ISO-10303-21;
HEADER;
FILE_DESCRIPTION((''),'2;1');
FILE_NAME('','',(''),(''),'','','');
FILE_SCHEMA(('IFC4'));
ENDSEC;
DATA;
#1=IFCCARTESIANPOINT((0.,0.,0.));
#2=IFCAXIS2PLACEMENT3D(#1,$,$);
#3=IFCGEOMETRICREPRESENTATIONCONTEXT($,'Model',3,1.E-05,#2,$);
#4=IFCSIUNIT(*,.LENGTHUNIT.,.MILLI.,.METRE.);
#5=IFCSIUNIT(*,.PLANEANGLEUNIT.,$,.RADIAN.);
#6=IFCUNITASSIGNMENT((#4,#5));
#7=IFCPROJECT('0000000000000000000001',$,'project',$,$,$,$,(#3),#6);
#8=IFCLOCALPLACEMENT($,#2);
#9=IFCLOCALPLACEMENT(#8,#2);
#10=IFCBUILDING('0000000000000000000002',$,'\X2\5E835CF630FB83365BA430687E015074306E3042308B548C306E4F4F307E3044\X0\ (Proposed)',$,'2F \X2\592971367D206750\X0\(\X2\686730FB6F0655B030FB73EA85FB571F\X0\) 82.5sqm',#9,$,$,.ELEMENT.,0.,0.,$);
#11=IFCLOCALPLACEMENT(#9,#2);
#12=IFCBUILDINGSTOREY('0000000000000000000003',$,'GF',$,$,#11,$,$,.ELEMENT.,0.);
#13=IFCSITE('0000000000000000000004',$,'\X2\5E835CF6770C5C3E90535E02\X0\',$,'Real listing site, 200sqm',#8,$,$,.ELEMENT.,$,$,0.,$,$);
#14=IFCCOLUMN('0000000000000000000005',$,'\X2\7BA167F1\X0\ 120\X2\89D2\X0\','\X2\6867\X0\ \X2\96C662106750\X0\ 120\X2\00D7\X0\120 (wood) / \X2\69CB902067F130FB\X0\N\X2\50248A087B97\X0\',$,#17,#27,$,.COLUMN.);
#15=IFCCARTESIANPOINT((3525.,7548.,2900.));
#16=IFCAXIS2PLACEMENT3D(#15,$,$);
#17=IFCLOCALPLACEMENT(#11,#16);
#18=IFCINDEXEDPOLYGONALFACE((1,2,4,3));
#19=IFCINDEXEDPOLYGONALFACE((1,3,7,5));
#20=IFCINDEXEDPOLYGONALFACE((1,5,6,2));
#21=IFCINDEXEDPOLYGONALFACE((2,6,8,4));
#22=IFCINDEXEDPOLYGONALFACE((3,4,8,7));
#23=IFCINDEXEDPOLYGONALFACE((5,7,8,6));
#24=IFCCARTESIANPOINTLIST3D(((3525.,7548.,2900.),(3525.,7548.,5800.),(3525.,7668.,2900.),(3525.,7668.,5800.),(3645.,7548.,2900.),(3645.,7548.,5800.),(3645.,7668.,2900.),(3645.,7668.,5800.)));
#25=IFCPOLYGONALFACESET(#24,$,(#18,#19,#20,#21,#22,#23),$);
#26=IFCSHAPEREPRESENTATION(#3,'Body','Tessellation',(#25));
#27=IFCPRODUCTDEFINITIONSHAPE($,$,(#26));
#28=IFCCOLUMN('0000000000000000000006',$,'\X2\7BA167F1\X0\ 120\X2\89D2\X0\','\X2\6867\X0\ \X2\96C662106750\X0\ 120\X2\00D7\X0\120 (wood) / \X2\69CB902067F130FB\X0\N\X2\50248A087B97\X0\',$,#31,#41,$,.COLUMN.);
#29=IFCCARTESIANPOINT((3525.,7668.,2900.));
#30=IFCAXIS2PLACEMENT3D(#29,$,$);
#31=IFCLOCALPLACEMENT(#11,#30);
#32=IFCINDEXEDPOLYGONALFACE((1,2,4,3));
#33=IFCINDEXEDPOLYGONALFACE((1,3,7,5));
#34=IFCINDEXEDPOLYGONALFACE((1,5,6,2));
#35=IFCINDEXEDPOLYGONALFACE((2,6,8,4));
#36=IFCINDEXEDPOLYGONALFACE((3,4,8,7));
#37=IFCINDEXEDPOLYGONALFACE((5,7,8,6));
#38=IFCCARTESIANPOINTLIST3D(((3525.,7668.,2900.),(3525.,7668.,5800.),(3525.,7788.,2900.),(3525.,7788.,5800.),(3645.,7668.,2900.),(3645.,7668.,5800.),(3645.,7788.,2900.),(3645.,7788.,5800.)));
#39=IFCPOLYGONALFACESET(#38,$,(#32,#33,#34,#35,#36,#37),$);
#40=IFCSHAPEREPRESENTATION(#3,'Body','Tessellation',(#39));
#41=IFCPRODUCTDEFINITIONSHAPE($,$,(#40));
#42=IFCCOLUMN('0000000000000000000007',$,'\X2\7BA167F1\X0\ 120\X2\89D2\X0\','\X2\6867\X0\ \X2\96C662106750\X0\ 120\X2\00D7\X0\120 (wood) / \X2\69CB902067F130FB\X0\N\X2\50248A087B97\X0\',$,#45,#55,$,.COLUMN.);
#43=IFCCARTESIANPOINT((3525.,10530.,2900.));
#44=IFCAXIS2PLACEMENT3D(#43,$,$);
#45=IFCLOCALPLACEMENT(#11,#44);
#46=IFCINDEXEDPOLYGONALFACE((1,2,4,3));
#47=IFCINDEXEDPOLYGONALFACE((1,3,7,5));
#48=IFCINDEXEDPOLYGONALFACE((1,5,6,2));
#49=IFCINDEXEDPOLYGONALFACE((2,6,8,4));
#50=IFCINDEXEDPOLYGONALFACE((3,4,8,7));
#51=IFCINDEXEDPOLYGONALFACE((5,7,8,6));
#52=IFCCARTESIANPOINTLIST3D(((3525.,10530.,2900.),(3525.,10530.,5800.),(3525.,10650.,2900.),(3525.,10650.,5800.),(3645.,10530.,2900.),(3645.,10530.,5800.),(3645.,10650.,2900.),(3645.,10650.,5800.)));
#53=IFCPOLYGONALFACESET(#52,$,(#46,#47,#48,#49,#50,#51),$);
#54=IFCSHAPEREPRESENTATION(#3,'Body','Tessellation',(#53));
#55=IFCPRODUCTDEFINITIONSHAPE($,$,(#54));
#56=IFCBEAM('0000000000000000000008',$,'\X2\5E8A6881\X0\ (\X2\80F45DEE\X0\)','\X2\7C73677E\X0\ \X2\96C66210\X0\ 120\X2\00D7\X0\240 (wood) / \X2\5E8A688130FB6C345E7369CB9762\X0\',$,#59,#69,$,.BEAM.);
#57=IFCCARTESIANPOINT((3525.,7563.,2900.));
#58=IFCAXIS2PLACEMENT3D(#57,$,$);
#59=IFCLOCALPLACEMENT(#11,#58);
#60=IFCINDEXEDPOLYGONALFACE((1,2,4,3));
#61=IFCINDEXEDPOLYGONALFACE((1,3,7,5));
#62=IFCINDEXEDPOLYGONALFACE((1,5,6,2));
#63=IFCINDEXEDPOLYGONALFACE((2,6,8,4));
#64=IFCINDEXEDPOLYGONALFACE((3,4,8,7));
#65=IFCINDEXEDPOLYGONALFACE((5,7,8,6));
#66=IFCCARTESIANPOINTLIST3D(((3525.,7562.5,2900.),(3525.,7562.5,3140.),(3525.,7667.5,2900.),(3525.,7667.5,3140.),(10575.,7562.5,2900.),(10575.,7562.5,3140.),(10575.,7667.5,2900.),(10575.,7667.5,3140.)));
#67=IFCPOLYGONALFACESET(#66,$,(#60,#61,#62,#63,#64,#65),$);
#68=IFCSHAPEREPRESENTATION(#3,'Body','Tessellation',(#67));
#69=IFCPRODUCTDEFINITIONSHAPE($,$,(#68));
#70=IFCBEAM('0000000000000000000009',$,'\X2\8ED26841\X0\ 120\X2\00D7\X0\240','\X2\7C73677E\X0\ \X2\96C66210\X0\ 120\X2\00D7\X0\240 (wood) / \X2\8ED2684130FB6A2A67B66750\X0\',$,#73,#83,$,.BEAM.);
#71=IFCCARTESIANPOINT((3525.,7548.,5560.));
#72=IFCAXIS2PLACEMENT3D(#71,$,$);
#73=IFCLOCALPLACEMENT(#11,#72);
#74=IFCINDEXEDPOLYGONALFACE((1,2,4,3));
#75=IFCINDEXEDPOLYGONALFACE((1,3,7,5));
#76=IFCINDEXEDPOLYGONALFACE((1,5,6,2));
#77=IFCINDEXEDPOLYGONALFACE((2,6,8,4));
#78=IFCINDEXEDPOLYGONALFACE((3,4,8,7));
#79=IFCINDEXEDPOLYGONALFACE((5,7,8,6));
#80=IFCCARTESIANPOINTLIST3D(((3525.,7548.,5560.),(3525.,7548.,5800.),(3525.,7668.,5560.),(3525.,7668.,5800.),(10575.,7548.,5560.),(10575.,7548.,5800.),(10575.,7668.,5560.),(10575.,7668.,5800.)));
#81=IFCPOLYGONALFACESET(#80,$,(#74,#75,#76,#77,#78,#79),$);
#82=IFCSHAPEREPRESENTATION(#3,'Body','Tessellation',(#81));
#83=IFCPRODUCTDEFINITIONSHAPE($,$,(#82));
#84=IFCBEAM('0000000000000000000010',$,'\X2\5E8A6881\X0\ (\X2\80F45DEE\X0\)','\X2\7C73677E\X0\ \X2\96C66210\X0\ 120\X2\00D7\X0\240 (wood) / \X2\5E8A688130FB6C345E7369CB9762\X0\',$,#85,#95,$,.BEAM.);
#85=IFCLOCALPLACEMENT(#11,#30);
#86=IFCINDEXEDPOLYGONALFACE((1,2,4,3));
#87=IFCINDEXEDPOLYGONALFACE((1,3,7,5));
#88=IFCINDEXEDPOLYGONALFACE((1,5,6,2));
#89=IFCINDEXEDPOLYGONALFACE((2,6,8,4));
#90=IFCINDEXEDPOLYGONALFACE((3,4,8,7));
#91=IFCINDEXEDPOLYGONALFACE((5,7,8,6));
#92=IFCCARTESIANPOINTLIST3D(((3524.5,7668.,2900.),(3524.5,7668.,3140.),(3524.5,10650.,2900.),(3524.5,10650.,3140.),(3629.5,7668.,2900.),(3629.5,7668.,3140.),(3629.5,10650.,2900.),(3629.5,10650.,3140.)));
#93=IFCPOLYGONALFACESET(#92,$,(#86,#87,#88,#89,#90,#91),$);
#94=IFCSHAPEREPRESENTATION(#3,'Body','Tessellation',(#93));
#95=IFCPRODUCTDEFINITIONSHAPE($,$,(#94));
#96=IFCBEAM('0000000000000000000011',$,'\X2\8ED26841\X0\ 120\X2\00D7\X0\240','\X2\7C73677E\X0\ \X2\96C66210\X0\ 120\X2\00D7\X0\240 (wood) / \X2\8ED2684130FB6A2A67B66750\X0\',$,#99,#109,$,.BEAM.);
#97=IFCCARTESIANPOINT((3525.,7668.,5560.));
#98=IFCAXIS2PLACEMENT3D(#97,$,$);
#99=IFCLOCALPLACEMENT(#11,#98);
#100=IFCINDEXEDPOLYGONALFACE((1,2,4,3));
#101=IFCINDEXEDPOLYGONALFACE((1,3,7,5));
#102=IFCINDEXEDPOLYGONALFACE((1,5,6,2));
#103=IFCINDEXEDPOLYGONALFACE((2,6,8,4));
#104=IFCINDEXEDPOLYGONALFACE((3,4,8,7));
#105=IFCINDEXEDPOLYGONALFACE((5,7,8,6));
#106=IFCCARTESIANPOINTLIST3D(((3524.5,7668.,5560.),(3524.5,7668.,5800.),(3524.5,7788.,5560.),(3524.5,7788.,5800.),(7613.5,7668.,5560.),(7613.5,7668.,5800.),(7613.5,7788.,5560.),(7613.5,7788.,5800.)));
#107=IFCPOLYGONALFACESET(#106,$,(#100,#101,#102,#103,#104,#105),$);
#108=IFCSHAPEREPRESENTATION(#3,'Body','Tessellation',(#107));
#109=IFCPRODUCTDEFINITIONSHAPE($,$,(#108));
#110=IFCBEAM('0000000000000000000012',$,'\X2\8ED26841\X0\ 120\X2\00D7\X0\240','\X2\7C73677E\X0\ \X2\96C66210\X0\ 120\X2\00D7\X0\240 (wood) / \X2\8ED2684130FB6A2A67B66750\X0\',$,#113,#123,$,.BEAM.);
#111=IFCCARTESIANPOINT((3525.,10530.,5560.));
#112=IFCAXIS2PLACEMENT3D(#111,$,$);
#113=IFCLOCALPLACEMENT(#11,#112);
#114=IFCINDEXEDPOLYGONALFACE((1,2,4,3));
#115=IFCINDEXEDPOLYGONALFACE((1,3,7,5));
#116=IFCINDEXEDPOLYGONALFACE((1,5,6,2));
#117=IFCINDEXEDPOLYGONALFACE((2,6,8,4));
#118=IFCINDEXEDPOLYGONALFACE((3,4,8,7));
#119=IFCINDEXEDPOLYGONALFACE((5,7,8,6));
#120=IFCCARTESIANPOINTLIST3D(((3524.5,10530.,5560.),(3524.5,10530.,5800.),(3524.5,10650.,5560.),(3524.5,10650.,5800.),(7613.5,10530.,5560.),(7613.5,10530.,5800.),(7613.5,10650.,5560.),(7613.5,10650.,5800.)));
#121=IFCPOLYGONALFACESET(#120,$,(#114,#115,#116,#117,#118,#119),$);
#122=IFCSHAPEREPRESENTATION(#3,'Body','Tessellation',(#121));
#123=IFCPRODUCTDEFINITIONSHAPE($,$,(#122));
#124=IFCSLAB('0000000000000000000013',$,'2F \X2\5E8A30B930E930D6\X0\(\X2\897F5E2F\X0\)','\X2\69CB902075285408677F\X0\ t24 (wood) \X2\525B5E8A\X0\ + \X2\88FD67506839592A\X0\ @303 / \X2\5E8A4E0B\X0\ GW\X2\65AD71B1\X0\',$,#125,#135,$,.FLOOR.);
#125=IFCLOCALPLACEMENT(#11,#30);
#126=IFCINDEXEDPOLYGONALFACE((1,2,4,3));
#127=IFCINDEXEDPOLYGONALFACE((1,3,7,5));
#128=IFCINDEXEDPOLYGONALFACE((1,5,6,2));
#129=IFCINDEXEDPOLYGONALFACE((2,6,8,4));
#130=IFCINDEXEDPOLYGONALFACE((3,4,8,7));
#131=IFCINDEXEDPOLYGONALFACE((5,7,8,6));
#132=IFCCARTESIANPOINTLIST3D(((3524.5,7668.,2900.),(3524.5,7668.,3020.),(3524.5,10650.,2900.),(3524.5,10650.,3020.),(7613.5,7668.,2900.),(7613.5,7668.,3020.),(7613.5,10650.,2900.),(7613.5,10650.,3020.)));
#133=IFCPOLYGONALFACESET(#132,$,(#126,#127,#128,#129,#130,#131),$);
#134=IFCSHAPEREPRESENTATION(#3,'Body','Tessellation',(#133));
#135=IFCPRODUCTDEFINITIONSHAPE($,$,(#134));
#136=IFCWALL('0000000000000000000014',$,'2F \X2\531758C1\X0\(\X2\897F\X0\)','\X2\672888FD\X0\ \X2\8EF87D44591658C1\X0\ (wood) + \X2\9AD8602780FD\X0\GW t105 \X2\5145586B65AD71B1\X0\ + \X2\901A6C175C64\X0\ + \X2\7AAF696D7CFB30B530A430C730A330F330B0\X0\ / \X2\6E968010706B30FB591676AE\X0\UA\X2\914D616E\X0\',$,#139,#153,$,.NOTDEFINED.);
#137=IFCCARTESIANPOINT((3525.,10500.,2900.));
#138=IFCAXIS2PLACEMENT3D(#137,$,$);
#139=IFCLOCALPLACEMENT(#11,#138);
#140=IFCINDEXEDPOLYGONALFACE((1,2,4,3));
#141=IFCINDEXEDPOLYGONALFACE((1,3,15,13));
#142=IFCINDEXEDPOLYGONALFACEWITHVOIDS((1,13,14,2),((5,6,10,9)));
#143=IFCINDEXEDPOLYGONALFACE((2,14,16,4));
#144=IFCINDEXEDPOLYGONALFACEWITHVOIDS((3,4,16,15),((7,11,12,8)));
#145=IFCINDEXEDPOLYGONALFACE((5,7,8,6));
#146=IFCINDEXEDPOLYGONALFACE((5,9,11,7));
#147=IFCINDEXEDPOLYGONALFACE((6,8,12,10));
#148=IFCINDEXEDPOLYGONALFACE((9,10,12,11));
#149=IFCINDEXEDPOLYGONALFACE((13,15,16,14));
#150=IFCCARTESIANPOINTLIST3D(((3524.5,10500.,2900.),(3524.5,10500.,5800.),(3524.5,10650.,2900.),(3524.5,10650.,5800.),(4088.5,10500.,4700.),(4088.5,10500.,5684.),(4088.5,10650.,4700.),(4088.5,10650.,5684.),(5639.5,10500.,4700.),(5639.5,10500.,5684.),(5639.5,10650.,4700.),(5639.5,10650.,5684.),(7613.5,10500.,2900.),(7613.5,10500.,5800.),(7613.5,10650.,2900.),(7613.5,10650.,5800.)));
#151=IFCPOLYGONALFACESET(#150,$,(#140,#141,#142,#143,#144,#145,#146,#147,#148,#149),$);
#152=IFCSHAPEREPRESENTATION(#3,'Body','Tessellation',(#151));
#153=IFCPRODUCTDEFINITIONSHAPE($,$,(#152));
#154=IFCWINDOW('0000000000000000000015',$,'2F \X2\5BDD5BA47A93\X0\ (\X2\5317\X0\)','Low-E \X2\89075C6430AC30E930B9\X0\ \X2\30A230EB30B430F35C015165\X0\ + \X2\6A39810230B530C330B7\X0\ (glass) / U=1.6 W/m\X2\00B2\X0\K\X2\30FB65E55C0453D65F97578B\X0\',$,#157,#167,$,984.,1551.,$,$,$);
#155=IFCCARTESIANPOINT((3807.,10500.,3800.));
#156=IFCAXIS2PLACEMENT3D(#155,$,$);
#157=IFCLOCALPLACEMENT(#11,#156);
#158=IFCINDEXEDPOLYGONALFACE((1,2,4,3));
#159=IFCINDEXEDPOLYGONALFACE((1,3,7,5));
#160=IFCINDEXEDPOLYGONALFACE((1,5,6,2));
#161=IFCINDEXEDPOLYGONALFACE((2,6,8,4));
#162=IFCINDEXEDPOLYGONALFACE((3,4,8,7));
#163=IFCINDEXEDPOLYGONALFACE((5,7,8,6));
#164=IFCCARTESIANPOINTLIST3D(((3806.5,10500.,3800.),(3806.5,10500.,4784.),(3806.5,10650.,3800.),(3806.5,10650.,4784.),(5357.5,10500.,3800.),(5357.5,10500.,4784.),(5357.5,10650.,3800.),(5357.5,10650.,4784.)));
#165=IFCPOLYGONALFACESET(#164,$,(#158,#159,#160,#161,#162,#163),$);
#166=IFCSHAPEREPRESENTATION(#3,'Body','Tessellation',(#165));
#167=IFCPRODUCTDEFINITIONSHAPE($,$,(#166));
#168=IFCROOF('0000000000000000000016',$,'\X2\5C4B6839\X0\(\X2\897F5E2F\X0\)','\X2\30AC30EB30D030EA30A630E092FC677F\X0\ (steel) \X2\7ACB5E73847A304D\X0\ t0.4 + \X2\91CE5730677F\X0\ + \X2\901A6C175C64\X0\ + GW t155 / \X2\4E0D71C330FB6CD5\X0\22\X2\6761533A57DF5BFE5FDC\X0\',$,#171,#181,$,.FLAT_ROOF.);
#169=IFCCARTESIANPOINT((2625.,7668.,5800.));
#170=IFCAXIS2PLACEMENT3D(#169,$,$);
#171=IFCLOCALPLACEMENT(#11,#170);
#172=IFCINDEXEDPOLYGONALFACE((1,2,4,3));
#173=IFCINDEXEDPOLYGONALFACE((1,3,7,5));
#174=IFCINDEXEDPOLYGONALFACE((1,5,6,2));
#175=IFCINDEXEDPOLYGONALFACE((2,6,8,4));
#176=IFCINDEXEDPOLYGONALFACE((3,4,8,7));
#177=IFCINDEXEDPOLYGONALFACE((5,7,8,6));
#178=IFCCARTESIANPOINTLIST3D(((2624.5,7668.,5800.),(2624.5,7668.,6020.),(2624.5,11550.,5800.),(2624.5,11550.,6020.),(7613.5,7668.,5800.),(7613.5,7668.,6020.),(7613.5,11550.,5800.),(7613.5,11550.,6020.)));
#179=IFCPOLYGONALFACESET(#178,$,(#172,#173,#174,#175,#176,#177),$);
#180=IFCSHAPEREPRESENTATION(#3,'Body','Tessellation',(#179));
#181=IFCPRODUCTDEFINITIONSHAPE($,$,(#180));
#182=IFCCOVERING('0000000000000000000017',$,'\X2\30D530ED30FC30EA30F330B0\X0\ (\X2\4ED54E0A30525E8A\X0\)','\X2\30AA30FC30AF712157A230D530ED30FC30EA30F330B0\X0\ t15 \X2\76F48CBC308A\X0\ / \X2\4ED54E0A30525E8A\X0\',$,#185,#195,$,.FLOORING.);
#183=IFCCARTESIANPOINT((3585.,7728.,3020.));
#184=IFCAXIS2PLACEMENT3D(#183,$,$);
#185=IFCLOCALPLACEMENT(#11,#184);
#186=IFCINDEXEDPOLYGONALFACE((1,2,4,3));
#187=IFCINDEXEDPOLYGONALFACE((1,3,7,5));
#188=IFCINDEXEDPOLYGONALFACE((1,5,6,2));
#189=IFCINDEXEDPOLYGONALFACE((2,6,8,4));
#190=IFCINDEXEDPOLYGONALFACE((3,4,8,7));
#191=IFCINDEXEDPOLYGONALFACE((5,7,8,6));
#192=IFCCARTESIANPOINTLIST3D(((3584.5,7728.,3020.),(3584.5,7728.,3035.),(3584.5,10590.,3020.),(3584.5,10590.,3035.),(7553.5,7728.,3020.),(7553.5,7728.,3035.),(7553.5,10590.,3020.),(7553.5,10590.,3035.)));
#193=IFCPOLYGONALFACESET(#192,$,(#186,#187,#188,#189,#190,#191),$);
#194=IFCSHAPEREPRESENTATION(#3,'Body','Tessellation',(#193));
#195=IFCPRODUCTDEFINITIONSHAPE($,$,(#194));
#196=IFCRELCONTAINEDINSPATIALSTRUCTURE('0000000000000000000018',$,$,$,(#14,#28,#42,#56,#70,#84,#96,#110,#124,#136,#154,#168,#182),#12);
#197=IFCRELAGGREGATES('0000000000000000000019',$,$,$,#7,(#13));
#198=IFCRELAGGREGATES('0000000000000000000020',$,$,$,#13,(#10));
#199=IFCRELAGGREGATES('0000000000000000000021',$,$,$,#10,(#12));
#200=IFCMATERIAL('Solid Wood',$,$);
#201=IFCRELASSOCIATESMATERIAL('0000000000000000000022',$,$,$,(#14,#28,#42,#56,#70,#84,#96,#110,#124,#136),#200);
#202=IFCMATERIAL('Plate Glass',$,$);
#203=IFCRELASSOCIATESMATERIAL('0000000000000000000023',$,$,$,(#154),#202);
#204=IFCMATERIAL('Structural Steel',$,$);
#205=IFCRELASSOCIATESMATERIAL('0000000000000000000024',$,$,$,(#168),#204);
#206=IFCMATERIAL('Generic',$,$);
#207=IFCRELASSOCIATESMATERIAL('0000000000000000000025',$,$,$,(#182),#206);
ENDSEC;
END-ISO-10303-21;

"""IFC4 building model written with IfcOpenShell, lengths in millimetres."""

from ifc_helpers import new_model, si_unit, frame, frame_2d, origin, place, context, project, spatial, rectangle, extrude, material, element, fill, save


model = new_model("IFC4")

# Units and contexts
model_context = context("Model", 3, precision=1e-05, world=origin())
ifc_project = project(units=[si_unit("LENGTHUNIT", "METRE", prefix="MILLI"), si_unit("PLANEANGLEUNIT", "RADIAN")], contexts=[model_context])

# Site, building, storey
site_placement = place(None, origin())
site = spatial("IfcSite", under=ifc_project, at=site_placement, Name="広島県尾道市", ObjectType="Real listing site, 200sqm", CompositionType="ELEMENT", RefElevation=0.0)
building_placement = place(site_placement, origin())
building = spatial("IfcBuilding", under=site, at=building_placement, Name="広島・茶室と縁側のある和の住まい (Proposed)", ObjectType="2F 天然素材(桧・漆喰・珪藻土) 82.5sqm", CompositionType="ELEMENT", ElevationOfRefHeight=0.0, ElevationOfTerrain=0.0)
storey_placement = place(building_placement, origin())
storey = spatial("IfcBuildingStorey", under=building, at=storey_placement, Name="GF", CompositionType="ELEMENT", Elevation=0.0)

# Columns
ifc_material_1 = material(Name="Solid Wood")
column_1_placement = place(storey_placement, frame((3525.0, 7548.0, 2900.0)))
element("IfcColumn", 1, at=column_1_placement, inside=storey, material=ifc_material_1, Name="管柱 120角", Description="桧 集成材 120×120 (wood) / 構造柱・N値計算", PredefinedType="COLUMN", context=model_context, shape_type="SweptSolid", body=[
    extrude(rectangle(XDim=120.0, YDim=120.0, at=frame_2d((60.0, 60.0))), frame((3525.0, 7548.0, 2900.0)), (0.0, 0.0, 1.0), 2900.0),
])
column_2_placement = place(storey_placement, frame((3525.0, 7668.0, 2900.0)))
element("IfcColumn", 2, at=column_2_placement, inside=storey, material=ifc_material_1, Name="管柱 120角", Description="桧 集成材 120×120 (wood) / 構造柱・N値計算", PredefinedType="COLUMN", context=model_context, shape_type="SweptSolid", body=[
    extrude(rectangle(XDim=120.0, YDim=120.0, at=frame_2d((60.0, 60.0))), frame((3525.0, 7668.0, 2900.0)), (0.0, 0.0, 1.0), 2900.0),
])
column_3_placement = place(storey_placement, frame((3525.0, 10530.0, 2900.0)))
element("IfcColumn", 3, at=column_3_placement, inside=storey, material=ifc_material_1, Name="管柱 120角", Description="桧 集成材 120×120 (wood) / 構造柱・N値計算", PredefinedType="COLUMN", context=model_context, shape_type="SweptSolid", body=[
    extrude(rectangle(XDim=120.0, YDim=120.0, at=frame_2d((60.0, 60.0))), frame((3525.0, 10530.0, 2900.0)), (0.0, 0.0, 1.0), 2900.0),
])

# Beams
beam_1_placement = place(storey_placement, frame((3525.0, 7563.0, 2900.0)))
element("IfcBeam", 4, at=beam_1_placement, inside=storey, material=ifc_material_1, Name="床梁 (胴差)", Description="米松 集成 120×240 (wood) / 床梁・水平構面", PredefinedType="BEAM", context=model_context, shape_type="SweptSolid", body=[
    extrude(rectangle(XDim=7050.0, YDim=105.0, at=frame_2d((3525.0, 52.0))), frame((3525.0, 7563.0, 2900.0)), (0.0, 0.0, 1.0), 240.0),
])
beam_2_placement = place(storey_placement, frame((3525.0, 7548.0, 5560.0)))
element("IfcBeam", 5, at=beam_2_placement, inside=storey, material=ifc_material_1, Name="軒桁 120×240", Description="米松 集成 120×240 (wood) / 軒桁・横架材", PredefinedType="BEAM", context=model_context, shape_type="SweptSolid", body=[
    extrude(rectangle(XDim=7050.0, YDim=120.0, at=frame_2d((3525.0, 60.0))), frame((3525.0, 7548.0, 5560.0)), (0.0, 0.0, 1.0), 240.0),
])
beam_3_placement = place(storey_placement, frame((3525.0, 7668.0, 2900.0)))
element("IfcBeam", 6, at=beam_3_placement, inside=storey, material=ifc_material_1, Name="床梁 (胴差)", Description="米松 集成 120×240 (wood) / 床梁・水平構面", PredefinedType="BEAM", context=model_context, shape_type="SweptSolid", body=[
    extrude(rectangle(XDim=105.0, YDim=2982.0, at=frame_2d((52.0, 1491.0))), frame((3525.0, 7668.0, 2900.0)), (0.0, 0.0, 1.0), 240.0),
])
beam_4_placement = place(storey_placement, frame((3525.0, 7668.0, 5560.0)))
element("IfcBeam", 7, at=beam_4_placement, inside=storey, material=ifc_material_1, Name="軒桁 120×240", Description="米松 集成 120×240 (wood) / 軒桁・横架材", PredefinedType="BEAM", context=model_context, shape_type="SweptSolid", body=[
    extrude(rectangle(XDim=4089.0, YDim=120.0, at=frame_2d((2044.0, 60.0))), frame((3525.0, 7668.0, 5560.0)), (0.0, 0.0, 1.0), 240.0),
])
beam_5_placement = place(storey_placement, frame((3525.0, 10530.0, 5560.0)))
element("IfcBeam", 8, at=beam_5_placement, inside=storey, material=ifc_material_1, Name="軒桁 120×240", Description="米松 集成 120×240 (wood) / 軒桁・横架材", PredefinedType="BEAM", context=model_context, shape_type="SweptSolid", body=[
    extrude(rectangle(XDim=4089.0, YDim=120.0, at=frame_2d((2044.0, 60.0))), frame((3525.0, 10530.0, 5560.0)), (0.0, 0.0, 1.0), 240.0),
])

# Slab
slab_placement = place(storey_placement, frame((3525.0, 7668.0, 2900.0)))
element("IfcSlab", 9, at=slab_placement, inside=storey, material=ifc_material_1, Name="2F 床スラブ(西帯)", Description="構造用合板 t24 (wood) 剛床 + 製材根太 @303 / 床下 GW断熱", PredefinedType="FLOOR", context=model_context, shape_type="SweptSolid", body=[
    extrude(rectangle(XDim=4089.0, YDim=2982.0, at=frame_2d((2044.0, 1491.0))), frame((3525.0, 7668.0, 2900.0)), (0.0, 0.0, 1.0), 120.0),
])

# Wall, opening, window
wall_1_placement = place(storey_placement, frame((3525.0, 10500.0, 2900.0)))
wall_1 = element("IfcWall", 10, at=wall_1_placement, inside=storey, material=ifc_material_1, Name="2F 北壁(西)", Description="木製 軸組外壁 (wood) + 高性能GW t105 充填断熱 + 通気層 + 窯業系サイディング / 準耐火・外皮UA配慮", PredefinedType="NOTDEFINED", context=model_context, shape_type="SweptSolid", body=[
    extrude(rectangle(XDim=4089.0, YDim=150.0, at=frame_2d((2044.0, 75.0))), frame((3525.0, 10500.0, 2900.0)), (0.0, 0.0, 1.0), 2900.0),
])
opening_placement = place(storey_placement, frame((3807.0, 10500.0, 3800.0)))
opening = element("IfcOpeningElement", 11, at=opening_placement, cuts=wall_1, PredefinedType="NOTDEFINED", context=model_context, shape_type="SweptSolid", body=[
    extrude(rectangle(XDim=1551.0, YDim=150.0, at=frame_2d((775.0, 75.0))), frame((3807.0, 10500.0, 3800.0)), (0.0, 0.0, 1.0), 984.0),
])
ifc_material_2 = material(Name="Plate Glass")
window_placement = place(storey_placement, frame((3807.0, 10500.0, 3800.0)))
window = element("IfcWindow", 12, at=window_placement, inside=storey, material=ifc_material_2, Name="2F 寝室窓 (北)", Description="Low-E 複層ガラス アルゴン封入 + 樹脂サッシ (glass) / U=1.6 W/m²K・日射取得型", OverallHeight=984.0, OverallWidth=1551.0, context=model_context, shape_type="SweptSolid", body=[
    extrude(rectangle(XDim=1551.0, YDim=150.0, at=frame_2d((775.0, 75.0))), frame((3807.0, 10500.0, 3800.0)), (0.0, 0.0, 1.0), 984.0),
])
fill(opening, window)

# Roof
ifc_material_3 = material(Name="Structural Steel")
for number, where, name in (
    (13, (2625.0, 7668.0, 5800.0), "屋根(西帯)"),
):
    element("IfcRoof", number, at=place(storey_placement, frame(where)), inside=storey, material=ifc_material_3, Name=name, Description="ガルバリウム鋼板 (steel) 立平葺き t0.4 + 野地板 + 通気層 + GW t155 / 不燃・法22条区域対応", PredefinedType="FLAT_ROOF", context=model_context, shape_type="SweptSolid", body=[
        extrude(rectangle(XDim=4989.0, YDim=3882.0, at=frame_2d((2494.0, 1941.0))), frame((2625.0, 7668.0, 5800.0)), (0.0, 0.0, 1.0), 220.0),
    ])

# Covering
ifc_material_4 = material(Name="Generic")
covering_placement = place(storey_placement, frame((3585.0, 7728.0, 3020.0)))
element("IfcCovering", 14, at=covering_placement, inside=storey, material=ifc_material_4, Name="フローリング (仕上げ床)", Description="オーク無垢フローリング t15 直貼り / 仕上げ床", PredefinedType="FLOORING", context=model_context, shape_type="SweptSolid", body=[
    extrude(rectangle(XDim=3969.0, YDim=2862.0, at=frame_2d((1984.0, 1431.0))), frame((3585.0, 7728.0, 3020.0)), (0.0, 0.0, 1.0), 15.0),
])

save(model, "model.ifc")
